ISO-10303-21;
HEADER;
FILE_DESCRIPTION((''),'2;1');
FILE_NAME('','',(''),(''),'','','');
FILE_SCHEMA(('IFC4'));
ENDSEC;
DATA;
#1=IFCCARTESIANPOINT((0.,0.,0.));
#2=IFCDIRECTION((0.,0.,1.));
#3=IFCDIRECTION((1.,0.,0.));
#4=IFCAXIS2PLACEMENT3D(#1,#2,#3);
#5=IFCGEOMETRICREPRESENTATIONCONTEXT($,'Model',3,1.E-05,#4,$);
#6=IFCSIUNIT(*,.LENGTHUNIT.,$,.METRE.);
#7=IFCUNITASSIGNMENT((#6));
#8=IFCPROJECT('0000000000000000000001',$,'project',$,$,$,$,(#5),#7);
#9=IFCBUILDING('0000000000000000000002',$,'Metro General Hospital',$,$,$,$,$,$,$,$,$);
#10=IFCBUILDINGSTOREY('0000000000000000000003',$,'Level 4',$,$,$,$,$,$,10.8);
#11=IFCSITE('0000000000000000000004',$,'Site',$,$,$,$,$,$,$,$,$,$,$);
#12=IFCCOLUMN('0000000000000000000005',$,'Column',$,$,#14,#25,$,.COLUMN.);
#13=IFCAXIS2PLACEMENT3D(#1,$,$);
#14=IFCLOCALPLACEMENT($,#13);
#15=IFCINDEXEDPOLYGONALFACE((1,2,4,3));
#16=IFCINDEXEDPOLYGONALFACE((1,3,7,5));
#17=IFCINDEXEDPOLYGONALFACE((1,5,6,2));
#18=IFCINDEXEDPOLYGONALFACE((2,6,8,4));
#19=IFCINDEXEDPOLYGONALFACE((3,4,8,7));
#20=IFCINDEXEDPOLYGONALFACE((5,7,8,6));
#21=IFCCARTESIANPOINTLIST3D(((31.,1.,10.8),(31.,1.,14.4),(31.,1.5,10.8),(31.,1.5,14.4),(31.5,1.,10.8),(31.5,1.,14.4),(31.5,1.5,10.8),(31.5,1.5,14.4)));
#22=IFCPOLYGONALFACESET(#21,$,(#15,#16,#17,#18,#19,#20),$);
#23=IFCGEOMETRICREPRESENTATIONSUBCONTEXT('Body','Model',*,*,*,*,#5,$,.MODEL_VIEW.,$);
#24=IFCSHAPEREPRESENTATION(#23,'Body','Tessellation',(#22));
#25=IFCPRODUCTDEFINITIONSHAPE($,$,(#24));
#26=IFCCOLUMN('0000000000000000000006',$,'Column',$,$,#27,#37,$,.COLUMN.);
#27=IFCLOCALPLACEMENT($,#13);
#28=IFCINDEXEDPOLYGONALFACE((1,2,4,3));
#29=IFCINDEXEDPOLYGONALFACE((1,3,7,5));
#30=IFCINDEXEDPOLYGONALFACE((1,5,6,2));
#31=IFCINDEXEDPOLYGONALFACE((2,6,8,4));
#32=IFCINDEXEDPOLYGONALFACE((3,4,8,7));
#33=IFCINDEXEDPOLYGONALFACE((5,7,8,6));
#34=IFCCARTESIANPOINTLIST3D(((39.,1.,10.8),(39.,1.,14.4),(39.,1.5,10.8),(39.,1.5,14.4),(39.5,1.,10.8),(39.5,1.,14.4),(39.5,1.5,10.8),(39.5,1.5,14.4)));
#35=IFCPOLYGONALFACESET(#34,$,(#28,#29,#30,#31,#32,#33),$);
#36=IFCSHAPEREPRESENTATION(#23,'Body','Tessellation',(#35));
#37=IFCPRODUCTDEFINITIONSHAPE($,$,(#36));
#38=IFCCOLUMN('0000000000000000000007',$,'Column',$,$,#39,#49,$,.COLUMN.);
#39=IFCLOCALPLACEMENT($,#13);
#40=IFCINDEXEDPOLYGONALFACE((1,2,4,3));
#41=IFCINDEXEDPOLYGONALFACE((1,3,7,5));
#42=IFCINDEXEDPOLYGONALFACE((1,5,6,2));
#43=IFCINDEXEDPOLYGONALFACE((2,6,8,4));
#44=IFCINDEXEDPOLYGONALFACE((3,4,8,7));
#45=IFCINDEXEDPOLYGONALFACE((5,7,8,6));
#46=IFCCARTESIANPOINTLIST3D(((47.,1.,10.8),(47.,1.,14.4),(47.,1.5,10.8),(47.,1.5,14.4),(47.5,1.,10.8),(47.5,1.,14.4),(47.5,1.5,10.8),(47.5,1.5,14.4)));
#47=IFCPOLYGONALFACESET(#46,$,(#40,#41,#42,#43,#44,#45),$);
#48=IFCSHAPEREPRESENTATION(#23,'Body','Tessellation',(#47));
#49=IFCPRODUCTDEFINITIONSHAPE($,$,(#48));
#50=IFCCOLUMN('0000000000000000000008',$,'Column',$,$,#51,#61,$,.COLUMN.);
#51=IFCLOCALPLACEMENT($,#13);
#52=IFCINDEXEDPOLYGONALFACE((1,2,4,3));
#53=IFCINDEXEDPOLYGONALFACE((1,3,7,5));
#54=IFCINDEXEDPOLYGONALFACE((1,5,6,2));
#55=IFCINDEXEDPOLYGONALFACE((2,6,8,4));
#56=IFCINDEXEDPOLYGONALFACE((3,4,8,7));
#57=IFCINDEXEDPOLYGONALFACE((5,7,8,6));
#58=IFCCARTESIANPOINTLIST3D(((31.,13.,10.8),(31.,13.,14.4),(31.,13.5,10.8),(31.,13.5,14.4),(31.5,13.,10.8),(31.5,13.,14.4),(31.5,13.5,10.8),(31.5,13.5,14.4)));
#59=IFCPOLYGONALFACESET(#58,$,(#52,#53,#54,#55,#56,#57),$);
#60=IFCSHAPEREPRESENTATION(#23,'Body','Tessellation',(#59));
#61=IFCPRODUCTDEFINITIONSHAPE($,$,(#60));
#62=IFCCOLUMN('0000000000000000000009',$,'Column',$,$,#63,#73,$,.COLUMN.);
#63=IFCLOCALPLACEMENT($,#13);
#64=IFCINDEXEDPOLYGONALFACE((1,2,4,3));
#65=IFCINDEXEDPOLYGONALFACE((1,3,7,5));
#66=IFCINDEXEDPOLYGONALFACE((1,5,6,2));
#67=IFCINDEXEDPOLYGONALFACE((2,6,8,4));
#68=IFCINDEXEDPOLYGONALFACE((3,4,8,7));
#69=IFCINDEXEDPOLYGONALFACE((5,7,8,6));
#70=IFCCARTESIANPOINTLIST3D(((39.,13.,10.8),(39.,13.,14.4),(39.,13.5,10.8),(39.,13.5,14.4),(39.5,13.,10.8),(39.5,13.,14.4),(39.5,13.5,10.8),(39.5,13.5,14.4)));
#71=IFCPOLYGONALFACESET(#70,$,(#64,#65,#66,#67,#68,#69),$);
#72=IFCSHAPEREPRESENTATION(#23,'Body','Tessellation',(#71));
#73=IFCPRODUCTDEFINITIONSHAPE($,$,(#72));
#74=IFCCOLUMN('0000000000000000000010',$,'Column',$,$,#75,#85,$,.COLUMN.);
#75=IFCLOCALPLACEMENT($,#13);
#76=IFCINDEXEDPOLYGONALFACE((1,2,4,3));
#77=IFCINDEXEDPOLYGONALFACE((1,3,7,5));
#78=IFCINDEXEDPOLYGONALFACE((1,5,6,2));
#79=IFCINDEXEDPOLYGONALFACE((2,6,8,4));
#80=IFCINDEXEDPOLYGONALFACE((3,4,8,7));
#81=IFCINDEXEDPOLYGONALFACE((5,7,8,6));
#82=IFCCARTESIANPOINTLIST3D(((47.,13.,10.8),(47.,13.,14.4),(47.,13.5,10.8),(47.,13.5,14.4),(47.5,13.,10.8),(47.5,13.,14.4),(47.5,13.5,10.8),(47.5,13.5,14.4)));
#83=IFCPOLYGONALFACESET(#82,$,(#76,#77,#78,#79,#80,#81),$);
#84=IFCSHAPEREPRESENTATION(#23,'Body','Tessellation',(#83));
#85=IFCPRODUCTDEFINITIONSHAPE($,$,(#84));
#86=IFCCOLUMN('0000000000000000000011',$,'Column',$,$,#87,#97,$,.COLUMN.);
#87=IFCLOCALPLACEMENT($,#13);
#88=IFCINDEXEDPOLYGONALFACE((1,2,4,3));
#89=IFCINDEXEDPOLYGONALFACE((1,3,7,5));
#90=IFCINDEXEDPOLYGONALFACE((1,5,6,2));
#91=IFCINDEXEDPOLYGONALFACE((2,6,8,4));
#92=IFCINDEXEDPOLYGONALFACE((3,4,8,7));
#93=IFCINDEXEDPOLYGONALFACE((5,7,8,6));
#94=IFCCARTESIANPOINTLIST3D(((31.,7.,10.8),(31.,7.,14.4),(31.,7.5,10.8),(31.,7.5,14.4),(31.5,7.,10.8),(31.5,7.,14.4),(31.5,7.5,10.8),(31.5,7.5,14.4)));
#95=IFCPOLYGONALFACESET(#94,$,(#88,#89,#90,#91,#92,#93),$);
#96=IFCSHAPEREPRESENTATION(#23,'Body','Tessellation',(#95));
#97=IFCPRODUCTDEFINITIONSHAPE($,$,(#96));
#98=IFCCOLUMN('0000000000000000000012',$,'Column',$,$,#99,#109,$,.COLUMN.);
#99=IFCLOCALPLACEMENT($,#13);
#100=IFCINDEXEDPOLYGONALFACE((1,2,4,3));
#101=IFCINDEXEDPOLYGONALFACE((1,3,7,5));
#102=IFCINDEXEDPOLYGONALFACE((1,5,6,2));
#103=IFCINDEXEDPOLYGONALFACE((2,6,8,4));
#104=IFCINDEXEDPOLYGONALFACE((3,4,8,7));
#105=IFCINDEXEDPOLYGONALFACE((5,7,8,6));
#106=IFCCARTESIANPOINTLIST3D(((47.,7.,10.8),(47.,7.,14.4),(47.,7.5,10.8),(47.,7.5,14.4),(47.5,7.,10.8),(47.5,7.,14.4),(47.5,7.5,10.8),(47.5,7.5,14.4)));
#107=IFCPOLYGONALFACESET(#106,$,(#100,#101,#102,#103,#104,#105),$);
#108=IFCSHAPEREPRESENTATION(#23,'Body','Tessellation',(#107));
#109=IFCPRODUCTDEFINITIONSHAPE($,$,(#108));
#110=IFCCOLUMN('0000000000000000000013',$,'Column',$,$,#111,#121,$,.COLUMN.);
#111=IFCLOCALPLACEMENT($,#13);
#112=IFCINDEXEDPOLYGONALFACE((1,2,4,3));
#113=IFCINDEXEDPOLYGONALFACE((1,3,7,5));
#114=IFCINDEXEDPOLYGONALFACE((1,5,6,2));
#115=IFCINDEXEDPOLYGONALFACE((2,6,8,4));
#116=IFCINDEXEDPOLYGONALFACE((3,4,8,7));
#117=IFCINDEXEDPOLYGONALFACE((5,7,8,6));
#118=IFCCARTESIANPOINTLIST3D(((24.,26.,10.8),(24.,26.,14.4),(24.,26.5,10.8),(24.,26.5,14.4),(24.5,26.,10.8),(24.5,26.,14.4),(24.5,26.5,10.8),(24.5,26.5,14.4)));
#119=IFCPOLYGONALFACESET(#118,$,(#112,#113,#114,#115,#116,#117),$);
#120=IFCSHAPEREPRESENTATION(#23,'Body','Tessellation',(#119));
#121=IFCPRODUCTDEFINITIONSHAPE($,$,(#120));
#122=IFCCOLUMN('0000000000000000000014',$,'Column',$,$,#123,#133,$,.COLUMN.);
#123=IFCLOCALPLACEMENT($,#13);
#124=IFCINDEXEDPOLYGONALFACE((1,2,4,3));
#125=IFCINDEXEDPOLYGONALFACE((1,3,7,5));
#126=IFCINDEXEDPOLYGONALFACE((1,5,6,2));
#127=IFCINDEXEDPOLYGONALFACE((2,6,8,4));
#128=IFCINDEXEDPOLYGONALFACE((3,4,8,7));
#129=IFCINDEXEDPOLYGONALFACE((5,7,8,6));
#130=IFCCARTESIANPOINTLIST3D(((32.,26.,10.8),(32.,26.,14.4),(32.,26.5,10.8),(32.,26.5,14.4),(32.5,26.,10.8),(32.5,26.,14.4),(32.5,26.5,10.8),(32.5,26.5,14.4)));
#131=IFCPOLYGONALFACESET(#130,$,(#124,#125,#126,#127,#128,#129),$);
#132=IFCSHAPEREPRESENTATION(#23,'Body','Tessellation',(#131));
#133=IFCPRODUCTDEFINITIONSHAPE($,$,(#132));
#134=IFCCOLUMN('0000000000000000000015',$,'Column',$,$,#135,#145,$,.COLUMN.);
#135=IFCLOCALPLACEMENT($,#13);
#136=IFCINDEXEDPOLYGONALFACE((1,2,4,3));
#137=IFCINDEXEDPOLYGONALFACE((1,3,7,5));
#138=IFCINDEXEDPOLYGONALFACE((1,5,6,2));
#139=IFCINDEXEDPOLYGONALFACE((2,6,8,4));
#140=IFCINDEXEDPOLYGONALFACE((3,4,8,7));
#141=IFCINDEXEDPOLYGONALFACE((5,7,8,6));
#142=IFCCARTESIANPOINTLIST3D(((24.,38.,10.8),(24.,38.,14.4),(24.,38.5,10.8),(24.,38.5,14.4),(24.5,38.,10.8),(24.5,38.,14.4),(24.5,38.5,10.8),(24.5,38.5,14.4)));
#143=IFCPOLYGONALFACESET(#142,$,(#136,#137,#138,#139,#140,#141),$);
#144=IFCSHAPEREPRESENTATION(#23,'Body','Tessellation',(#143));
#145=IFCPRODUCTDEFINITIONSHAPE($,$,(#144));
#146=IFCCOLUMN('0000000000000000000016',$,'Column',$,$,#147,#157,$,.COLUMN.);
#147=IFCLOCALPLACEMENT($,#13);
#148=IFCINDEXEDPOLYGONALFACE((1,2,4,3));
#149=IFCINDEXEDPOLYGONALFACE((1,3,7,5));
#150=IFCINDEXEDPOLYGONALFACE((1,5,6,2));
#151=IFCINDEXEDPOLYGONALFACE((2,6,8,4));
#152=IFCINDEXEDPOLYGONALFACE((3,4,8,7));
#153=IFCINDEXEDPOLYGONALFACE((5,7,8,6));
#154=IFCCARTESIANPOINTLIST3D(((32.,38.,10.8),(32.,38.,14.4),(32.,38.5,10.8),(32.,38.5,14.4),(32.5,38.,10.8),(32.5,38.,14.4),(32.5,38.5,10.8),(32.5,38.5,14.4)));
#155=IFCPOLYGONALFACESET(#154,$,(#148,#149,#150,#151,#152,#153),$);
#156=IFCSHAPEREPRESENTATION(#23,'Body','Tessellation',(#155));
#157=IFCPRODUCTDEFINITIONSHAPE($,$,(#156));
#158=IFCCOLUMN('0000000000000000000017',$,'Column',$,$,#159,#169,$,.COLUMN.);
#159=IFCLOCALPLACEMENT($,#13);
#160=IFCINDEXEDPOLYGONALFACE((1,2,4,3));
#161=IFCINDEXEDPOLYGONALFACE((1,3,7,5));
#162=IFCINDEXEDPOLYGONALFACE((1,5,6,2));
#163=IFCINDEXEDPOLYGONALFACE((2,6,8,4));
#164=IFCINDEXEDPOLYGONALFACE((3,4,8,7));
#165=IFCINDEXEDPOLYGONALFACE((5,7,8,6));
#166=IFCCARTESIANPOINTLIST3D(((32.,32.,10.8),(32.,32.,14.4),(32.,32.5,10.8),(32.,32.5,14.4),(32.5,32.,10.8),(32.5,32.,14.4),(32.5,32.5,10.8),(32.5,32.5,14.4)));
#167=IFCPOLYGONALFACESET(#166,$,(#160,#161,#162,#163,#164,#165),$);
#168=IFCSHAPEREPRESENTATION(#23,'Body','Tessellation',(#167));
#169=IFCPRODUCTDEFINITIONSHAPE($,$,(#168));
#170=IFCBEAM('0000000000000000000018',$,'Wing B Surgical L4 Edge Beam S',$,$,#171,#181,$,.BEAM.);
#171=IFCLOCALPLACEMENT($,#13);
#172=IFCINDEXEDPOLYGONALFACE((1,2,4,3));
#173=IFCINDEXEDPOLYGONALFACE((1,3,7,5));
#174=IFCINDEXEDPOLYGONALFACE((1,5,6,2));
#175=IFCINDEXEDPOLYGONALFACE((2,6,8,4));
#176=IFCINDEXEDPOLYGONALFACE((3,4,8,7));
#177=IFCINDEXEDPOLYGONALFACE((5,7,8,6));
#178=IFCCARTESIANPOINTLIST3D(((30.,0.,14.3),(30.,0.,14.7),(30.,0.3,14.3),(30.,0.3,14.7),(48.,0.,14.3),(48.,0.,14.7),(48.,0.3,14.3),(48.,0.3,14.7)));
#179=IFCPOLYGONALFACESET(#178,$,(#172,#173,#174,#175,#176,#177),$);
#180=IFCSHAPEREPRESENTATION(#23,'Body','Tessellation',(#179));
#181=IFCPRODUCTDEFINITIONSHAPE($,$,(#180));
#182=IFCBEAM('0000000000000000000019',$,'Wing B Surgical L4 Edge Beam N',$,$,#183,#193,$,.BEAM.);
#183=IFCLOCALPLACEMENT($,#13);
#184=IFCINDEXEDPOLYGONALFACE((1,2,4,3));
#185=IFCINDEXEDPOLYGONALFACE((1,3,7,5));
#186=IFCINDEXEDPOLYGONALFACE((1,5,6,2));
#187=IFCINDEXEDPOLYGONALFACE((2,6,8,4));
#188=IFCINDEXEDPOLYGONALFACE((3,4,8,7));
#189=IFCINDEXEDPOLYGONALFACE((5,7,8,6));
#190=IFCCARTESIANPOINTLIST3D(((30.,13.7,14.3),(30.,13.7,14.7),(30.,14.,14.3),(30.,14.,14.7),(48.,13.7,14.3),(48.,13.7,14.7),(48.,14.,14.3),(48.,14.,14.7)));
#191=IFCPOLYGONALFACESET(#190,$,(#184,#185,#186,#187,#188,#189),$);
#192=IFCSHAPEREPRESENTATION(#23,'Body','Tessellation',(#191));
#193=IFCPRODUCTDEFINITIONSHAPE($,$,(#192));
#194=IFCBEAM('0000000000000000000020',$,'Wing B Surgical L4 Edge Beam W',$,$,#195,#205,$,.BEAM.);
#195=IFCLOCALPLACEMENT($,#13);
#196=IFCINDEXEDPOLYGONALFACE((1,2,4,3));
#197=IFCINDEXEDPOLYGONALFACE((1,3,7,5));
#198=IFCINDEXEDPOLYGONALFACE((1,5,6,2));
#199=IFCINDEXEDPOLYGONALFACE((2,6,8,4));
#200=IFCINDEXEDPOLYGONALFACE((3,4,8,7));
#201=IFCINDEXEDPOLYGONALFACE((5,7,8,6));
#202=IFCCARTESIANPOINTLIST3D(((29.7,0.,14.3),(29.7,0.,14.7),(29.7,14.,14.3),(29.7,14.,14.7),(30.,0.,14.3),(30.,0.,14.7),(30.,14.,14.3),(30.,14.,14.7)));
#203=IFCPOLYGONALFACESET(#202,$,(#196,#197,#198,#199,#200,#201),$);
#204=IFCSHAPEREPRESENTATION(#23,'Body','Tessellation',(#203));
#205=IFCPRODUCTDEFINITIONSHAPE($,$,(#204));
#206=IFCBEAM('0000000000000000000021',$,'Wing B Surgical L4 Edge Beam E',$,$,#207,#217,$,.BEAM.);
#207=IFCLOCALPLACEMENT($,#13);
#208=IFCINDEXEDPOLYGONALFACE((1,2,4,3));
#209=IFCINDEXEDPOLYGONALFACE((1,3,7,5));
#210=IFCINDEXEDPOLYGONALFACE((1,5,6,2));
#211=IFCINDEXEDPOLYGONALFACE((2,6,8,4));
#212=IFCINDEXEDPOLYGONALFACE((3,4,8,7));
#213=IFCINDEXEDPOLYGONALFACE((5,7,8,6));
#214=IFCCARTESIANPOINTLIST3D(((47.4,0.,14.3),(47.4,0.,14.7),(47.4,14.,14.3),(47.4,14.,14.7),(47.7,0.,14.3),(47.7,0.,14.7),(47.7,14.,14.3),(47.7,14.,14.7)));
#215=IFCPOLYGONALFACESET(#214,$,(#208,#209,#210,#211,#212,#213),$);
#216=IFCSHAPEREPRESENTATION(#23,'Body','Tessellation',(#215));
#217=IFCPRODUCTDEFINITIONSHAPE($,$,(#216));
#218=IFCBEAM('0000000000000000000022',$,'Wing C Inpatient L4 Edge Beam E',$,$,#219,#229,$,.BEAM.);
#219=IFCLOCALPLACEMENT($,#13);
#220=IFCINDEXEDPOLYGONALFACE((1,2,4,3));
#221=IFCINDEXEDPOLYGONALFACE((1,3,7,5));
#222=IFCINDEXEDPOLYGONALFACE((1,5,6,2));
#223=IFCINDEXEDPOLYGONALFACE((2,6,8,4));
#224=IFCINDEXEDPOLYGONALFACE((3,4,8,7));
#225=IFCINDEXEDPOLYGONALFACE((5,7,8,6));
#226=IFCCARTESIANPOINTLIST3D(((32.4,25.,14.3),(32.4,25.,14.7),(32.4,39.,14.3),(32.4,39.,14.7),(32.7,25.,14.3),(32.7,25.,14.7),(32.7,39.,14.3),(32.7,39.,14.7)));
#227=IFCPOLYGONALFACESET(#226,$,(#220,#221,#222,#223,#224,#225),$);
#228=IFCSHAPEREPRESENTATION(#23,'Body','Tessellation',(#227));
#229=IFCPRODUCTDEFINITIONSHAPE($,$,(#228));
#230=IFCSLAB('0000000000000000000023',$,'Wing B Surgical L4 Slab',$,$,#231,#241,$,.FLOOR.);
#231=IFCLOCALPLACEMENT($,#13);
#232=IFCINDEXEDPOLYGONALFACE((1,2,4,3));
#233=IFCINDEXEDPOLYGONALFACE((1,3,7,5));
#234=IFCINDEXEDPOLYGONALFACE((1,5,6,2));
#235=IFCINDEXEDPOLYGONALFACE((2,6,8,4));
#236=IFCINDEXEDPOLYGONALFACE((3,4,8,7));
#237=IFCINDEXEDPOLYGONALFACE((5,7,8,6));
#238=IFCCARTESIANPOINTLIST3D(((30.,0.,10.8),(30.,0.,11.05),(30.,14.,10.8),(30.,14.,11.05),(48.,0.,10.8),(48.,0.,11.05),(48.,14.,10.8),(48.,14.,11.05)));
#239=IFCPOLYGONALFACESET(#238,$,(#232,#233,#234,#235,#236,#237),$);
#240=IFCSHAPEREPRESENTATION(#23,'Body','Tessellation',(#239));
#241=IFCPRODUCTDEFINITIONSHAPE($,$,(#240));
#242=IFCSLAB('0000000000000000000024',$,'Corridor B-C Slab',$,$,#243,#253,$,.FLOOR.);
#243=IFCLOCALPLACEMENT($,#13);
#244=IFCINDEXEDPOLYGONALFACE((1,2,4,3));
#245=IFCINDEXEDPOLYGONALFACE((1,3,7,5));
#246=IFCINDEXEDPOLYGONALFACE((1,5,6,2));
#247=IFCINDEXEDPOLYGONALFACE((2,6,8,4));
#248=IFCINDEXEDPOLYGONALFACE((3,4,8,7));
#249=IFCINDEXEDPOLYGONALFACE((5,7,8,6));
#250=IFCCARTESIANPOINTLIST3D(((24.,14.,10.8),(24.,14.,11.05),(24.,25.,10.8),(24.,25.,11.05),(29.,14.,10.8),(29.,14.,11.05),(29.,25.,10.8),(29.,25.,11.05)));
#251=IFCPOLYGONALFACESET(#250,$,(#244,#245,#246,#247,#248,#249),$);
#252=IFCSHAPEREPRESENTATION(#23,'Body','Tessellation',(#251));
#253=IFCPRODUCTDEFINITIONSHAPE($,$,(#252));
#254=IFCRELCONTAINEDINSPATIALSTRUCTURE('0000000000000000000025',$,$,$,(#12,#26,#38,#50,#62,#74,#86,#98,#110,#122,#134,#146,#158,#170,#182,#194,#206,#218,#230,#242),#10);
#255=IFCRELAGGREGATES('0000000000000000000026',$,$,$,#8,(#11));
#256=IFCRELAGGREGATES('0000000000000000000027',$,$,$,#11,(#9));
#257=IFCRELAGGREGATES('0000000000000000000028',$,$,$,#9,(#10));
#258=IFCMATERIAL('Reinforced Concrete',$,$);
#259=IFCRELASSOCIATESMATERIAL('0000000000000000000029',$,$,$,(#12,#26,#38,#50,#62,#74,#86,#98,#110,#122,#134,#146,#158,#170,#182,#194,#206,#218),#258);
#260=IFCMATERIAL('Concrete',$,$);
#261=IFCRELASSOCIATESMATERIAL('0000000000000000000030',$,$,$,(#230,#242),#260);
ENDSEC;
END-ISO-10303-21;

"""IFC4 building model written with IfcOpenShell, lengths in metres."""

from ifc_helpers import new_model, si_unit, frame, origin_with_axes, place, context, subcontext, project, spatial, line, indexed_curve, outline, extrude, material, element, save


model = new_model("IFC4")

# Units and contexts
model_context = context("Model", 3, precision=1e-05, world=origin_with_axes())
body_context = subcontext(model_context, "Body", "Model", "MODEL_VIEW")
ifc_project = project(units=[si_unit("LENGTHUNIT", "METRE")], contexts=[model_context])

# Site, building, storey
site = spatial("IfcSite", under=ifc_project, Name="Site")
building = spatial("IfcBuilding", under=site, Name="Metro General Hospital")
storey = spatial("IfcBuildingStorey", under=building, Name="Level 4", Elevation=10.8)

# Columns
ifc_material_1 = material(Name="Reinforced Concrete")
for number, where, z_axis, x_axis, name in (
    (1, (31.0, 1.0, 10.8), (0.0, 0.0, 1.0), (1.0, 0.0, 0.0), "Column"),
    (2, (39.0, 1.0, 10.8), (0.0, 0.0, 1.0), (1.0, 0.0, 0.0), "Column"),
    (3, (47.0, 1.0, 10.8), (0.0, 0.0, 1.0), (1.0, 0.0, 0.0), "Column"),
    (4, (31.0, 13.0, 10.8), (0.0, 0.0, 1.0), (1.0, 0.0, 0.0), "Column"),
    (5, (39.0, 13.0, 10.8), (0.0, 0.0, 1.0), (1.0, 0.0, 0.0), "Column"),
    (6, (47.0, 13.0, 10.8), (0.0, 0.0, 1.0), (1.0, 0.0, 0.0), "Column"),
    (7, (31.0, 7.0, 10.8), (0.0, 0.0, 1.0), (1.0, 0.0, 0.0), "Column"),
    (8, (47.0, 7.0, 10.8), (0.0, 0.0, 1.0), (1.0, 0.0, 0.0), "Column"),
    (9, (24.0, 26.0, 10.8), (0.0, 0.0, 1.0), (1.0, 0.0, 0.0), "Column"),
    (10, (32.0, 26.0, 10.8), (0.0, 0.0, 1.0), (1.0, 0.0, 0.0), "Column"),
    (11, (24.0, 38.0, 10.8), (0.0, 0.0, 1.0), (1.0, 0.0, 0.0), "Column"),
    (12, (32.0, 38.0, 10.8), (0.0, 0.0, 1.0), (1.0, 0.0, 0.0), "Column"),
    (13, (32.0, 32.0, 10.8), (0.0, 0.0, 1.0), (1.0, 0.0, 0.0), "Column"),
):
    element("IfcColumn", number, at=place(None, frame(where, z_axis=z_axis, x_axis=x_axis)), inside=storey, material=ifc_material_1, Name=name, PredefinedType="COLUMN", context=body_context, shape_type="SweptSolid", body=[
        extrude(outline(indexed_curve([(0.0, 0.0), (0.5, 0.0), (0.5, 0.5), (0.0, 0.5)], segments=[line(1, 2, 3, 4, 1)])), origin_with_axes(), (0.0, 0.0, 1.0), 3.6),
    ])

# Beams
for number, where, z_axis, x_axis, name in (
    (14, (30.0, 0.0, 14.3), (0.0, 0.0, 1.0), (1.0, 0.0, 0.0), "Wing B Surgical L4 Edge Beam S"),
    (15, (30.0, 13.7, 14.3), (0.0, 0.0, 1.0), (1.0, 0.0, 0.0), "Wing B Surgical L4 Edge Beam N"),
):
    element("IfcBeam", number, at=place(None, frame(where, z_axis=z_axis, x_axis=x_axis)), inside=storey, material=ifc_material_1, Name=name, PredefinedType="BEAM", context=body_context, shape_type="SweptSolid", body=[
        extrude(outline(indexed_curve([(0.0, 0.0), (18.0, 0.0), (18.0, 0.3), (0.0, 0.3)], segments=[line(1, 2, 3, 4, 1)])), origin_with_axes(), (0.0, 0.0, 1.0), 0.4),
    ])
for number, where, z_axis, x_axis, name in (
    (16, (30.0, 0.0, 14.3), (0.0, 0.0, 1.0), (0.0, 1.0, 0.0), "Wing B Surgical L4 Edge Beam W"),
    (17, (47.7, 0.0, 14.3), (0.0, 0.0, 1.0), (0.0, 1.0, 0.0), "Wing B Surgical L4 Edge Beam E"),
    (18, (32.7, 25.0, 14.3), (0.0, 0.0, 1.0), (0.0, 1.0, 0.0), "Wing C Inpatient L4 Edge Beam E"),
):
    element("IfcBeam", number, at=place(None, frame(where, z_axis=z_axis, x_axis=x_axis)), inside=storey, material=ifc_material_1, Name=name, PredefinedType="BEAM", context=body_context, shape_type="SweptSolid", body=[
        extrude(outline(indexed_curve([(0.0, 0.0), (14.0, 0.0), (14.0, 0.3), (0.0, 0.3)], segments=[line(1, 2, 3, 4, 1)])), origin_with_axes(), (0.0, 0.0, 1.0), 0.4),
    ])

# Slabs
ifc_material_2 = material(Name="Concrete")
slab_1_placement = place(None, frame((30.0, 0.0, 10.8), z_axis=(0.0, 0.0, 1.0), x_axis=(1.0, 0.0, 0.0)))
element("IfcSlab", 19, at=slab_1_placement, inside=storey, material=ifc_material_2, Name="Wing B Surgical L4 Slab", PredefinedType="FLOOR", context=body_context, shape_type="SweptSolid", body=[
    extrude(outline(indexed_curve([(0.0, 0.0), (18.0, 0.0), (18.0, 14.0), (0.0, 14.0)], segments=[line(1, 2, 3, 4, 1)])), origin_with_axes(), (0.0, 0.0, 1.0), 0.25),
])
slab_2_placement = place(None, frame((24.0, 14.0, 10.8), z_axis=(0.0, 0.0, 1.0), x_axis=(1.0, 0.0, 0.0)))
element("IfcSlab", 20, at=slab_2_placement, inside=storey, material=ifc_material_2, Name="Corridor B-C Slab", PredefinedType="FLOOR", context=body_context, shape_type="SweptSolid", body=[
    extrude(outline(indexed_curve([(0.0, 0.0), (5.0, 0.0), (5.0, 11.0), (0.0, 11.0)], segments=[line(1, 2, 3, 4, 1)])), origin_with_axes(), (0.0, 0.0, 1.0), 0.25),
])

save(model, "model.ifc")
